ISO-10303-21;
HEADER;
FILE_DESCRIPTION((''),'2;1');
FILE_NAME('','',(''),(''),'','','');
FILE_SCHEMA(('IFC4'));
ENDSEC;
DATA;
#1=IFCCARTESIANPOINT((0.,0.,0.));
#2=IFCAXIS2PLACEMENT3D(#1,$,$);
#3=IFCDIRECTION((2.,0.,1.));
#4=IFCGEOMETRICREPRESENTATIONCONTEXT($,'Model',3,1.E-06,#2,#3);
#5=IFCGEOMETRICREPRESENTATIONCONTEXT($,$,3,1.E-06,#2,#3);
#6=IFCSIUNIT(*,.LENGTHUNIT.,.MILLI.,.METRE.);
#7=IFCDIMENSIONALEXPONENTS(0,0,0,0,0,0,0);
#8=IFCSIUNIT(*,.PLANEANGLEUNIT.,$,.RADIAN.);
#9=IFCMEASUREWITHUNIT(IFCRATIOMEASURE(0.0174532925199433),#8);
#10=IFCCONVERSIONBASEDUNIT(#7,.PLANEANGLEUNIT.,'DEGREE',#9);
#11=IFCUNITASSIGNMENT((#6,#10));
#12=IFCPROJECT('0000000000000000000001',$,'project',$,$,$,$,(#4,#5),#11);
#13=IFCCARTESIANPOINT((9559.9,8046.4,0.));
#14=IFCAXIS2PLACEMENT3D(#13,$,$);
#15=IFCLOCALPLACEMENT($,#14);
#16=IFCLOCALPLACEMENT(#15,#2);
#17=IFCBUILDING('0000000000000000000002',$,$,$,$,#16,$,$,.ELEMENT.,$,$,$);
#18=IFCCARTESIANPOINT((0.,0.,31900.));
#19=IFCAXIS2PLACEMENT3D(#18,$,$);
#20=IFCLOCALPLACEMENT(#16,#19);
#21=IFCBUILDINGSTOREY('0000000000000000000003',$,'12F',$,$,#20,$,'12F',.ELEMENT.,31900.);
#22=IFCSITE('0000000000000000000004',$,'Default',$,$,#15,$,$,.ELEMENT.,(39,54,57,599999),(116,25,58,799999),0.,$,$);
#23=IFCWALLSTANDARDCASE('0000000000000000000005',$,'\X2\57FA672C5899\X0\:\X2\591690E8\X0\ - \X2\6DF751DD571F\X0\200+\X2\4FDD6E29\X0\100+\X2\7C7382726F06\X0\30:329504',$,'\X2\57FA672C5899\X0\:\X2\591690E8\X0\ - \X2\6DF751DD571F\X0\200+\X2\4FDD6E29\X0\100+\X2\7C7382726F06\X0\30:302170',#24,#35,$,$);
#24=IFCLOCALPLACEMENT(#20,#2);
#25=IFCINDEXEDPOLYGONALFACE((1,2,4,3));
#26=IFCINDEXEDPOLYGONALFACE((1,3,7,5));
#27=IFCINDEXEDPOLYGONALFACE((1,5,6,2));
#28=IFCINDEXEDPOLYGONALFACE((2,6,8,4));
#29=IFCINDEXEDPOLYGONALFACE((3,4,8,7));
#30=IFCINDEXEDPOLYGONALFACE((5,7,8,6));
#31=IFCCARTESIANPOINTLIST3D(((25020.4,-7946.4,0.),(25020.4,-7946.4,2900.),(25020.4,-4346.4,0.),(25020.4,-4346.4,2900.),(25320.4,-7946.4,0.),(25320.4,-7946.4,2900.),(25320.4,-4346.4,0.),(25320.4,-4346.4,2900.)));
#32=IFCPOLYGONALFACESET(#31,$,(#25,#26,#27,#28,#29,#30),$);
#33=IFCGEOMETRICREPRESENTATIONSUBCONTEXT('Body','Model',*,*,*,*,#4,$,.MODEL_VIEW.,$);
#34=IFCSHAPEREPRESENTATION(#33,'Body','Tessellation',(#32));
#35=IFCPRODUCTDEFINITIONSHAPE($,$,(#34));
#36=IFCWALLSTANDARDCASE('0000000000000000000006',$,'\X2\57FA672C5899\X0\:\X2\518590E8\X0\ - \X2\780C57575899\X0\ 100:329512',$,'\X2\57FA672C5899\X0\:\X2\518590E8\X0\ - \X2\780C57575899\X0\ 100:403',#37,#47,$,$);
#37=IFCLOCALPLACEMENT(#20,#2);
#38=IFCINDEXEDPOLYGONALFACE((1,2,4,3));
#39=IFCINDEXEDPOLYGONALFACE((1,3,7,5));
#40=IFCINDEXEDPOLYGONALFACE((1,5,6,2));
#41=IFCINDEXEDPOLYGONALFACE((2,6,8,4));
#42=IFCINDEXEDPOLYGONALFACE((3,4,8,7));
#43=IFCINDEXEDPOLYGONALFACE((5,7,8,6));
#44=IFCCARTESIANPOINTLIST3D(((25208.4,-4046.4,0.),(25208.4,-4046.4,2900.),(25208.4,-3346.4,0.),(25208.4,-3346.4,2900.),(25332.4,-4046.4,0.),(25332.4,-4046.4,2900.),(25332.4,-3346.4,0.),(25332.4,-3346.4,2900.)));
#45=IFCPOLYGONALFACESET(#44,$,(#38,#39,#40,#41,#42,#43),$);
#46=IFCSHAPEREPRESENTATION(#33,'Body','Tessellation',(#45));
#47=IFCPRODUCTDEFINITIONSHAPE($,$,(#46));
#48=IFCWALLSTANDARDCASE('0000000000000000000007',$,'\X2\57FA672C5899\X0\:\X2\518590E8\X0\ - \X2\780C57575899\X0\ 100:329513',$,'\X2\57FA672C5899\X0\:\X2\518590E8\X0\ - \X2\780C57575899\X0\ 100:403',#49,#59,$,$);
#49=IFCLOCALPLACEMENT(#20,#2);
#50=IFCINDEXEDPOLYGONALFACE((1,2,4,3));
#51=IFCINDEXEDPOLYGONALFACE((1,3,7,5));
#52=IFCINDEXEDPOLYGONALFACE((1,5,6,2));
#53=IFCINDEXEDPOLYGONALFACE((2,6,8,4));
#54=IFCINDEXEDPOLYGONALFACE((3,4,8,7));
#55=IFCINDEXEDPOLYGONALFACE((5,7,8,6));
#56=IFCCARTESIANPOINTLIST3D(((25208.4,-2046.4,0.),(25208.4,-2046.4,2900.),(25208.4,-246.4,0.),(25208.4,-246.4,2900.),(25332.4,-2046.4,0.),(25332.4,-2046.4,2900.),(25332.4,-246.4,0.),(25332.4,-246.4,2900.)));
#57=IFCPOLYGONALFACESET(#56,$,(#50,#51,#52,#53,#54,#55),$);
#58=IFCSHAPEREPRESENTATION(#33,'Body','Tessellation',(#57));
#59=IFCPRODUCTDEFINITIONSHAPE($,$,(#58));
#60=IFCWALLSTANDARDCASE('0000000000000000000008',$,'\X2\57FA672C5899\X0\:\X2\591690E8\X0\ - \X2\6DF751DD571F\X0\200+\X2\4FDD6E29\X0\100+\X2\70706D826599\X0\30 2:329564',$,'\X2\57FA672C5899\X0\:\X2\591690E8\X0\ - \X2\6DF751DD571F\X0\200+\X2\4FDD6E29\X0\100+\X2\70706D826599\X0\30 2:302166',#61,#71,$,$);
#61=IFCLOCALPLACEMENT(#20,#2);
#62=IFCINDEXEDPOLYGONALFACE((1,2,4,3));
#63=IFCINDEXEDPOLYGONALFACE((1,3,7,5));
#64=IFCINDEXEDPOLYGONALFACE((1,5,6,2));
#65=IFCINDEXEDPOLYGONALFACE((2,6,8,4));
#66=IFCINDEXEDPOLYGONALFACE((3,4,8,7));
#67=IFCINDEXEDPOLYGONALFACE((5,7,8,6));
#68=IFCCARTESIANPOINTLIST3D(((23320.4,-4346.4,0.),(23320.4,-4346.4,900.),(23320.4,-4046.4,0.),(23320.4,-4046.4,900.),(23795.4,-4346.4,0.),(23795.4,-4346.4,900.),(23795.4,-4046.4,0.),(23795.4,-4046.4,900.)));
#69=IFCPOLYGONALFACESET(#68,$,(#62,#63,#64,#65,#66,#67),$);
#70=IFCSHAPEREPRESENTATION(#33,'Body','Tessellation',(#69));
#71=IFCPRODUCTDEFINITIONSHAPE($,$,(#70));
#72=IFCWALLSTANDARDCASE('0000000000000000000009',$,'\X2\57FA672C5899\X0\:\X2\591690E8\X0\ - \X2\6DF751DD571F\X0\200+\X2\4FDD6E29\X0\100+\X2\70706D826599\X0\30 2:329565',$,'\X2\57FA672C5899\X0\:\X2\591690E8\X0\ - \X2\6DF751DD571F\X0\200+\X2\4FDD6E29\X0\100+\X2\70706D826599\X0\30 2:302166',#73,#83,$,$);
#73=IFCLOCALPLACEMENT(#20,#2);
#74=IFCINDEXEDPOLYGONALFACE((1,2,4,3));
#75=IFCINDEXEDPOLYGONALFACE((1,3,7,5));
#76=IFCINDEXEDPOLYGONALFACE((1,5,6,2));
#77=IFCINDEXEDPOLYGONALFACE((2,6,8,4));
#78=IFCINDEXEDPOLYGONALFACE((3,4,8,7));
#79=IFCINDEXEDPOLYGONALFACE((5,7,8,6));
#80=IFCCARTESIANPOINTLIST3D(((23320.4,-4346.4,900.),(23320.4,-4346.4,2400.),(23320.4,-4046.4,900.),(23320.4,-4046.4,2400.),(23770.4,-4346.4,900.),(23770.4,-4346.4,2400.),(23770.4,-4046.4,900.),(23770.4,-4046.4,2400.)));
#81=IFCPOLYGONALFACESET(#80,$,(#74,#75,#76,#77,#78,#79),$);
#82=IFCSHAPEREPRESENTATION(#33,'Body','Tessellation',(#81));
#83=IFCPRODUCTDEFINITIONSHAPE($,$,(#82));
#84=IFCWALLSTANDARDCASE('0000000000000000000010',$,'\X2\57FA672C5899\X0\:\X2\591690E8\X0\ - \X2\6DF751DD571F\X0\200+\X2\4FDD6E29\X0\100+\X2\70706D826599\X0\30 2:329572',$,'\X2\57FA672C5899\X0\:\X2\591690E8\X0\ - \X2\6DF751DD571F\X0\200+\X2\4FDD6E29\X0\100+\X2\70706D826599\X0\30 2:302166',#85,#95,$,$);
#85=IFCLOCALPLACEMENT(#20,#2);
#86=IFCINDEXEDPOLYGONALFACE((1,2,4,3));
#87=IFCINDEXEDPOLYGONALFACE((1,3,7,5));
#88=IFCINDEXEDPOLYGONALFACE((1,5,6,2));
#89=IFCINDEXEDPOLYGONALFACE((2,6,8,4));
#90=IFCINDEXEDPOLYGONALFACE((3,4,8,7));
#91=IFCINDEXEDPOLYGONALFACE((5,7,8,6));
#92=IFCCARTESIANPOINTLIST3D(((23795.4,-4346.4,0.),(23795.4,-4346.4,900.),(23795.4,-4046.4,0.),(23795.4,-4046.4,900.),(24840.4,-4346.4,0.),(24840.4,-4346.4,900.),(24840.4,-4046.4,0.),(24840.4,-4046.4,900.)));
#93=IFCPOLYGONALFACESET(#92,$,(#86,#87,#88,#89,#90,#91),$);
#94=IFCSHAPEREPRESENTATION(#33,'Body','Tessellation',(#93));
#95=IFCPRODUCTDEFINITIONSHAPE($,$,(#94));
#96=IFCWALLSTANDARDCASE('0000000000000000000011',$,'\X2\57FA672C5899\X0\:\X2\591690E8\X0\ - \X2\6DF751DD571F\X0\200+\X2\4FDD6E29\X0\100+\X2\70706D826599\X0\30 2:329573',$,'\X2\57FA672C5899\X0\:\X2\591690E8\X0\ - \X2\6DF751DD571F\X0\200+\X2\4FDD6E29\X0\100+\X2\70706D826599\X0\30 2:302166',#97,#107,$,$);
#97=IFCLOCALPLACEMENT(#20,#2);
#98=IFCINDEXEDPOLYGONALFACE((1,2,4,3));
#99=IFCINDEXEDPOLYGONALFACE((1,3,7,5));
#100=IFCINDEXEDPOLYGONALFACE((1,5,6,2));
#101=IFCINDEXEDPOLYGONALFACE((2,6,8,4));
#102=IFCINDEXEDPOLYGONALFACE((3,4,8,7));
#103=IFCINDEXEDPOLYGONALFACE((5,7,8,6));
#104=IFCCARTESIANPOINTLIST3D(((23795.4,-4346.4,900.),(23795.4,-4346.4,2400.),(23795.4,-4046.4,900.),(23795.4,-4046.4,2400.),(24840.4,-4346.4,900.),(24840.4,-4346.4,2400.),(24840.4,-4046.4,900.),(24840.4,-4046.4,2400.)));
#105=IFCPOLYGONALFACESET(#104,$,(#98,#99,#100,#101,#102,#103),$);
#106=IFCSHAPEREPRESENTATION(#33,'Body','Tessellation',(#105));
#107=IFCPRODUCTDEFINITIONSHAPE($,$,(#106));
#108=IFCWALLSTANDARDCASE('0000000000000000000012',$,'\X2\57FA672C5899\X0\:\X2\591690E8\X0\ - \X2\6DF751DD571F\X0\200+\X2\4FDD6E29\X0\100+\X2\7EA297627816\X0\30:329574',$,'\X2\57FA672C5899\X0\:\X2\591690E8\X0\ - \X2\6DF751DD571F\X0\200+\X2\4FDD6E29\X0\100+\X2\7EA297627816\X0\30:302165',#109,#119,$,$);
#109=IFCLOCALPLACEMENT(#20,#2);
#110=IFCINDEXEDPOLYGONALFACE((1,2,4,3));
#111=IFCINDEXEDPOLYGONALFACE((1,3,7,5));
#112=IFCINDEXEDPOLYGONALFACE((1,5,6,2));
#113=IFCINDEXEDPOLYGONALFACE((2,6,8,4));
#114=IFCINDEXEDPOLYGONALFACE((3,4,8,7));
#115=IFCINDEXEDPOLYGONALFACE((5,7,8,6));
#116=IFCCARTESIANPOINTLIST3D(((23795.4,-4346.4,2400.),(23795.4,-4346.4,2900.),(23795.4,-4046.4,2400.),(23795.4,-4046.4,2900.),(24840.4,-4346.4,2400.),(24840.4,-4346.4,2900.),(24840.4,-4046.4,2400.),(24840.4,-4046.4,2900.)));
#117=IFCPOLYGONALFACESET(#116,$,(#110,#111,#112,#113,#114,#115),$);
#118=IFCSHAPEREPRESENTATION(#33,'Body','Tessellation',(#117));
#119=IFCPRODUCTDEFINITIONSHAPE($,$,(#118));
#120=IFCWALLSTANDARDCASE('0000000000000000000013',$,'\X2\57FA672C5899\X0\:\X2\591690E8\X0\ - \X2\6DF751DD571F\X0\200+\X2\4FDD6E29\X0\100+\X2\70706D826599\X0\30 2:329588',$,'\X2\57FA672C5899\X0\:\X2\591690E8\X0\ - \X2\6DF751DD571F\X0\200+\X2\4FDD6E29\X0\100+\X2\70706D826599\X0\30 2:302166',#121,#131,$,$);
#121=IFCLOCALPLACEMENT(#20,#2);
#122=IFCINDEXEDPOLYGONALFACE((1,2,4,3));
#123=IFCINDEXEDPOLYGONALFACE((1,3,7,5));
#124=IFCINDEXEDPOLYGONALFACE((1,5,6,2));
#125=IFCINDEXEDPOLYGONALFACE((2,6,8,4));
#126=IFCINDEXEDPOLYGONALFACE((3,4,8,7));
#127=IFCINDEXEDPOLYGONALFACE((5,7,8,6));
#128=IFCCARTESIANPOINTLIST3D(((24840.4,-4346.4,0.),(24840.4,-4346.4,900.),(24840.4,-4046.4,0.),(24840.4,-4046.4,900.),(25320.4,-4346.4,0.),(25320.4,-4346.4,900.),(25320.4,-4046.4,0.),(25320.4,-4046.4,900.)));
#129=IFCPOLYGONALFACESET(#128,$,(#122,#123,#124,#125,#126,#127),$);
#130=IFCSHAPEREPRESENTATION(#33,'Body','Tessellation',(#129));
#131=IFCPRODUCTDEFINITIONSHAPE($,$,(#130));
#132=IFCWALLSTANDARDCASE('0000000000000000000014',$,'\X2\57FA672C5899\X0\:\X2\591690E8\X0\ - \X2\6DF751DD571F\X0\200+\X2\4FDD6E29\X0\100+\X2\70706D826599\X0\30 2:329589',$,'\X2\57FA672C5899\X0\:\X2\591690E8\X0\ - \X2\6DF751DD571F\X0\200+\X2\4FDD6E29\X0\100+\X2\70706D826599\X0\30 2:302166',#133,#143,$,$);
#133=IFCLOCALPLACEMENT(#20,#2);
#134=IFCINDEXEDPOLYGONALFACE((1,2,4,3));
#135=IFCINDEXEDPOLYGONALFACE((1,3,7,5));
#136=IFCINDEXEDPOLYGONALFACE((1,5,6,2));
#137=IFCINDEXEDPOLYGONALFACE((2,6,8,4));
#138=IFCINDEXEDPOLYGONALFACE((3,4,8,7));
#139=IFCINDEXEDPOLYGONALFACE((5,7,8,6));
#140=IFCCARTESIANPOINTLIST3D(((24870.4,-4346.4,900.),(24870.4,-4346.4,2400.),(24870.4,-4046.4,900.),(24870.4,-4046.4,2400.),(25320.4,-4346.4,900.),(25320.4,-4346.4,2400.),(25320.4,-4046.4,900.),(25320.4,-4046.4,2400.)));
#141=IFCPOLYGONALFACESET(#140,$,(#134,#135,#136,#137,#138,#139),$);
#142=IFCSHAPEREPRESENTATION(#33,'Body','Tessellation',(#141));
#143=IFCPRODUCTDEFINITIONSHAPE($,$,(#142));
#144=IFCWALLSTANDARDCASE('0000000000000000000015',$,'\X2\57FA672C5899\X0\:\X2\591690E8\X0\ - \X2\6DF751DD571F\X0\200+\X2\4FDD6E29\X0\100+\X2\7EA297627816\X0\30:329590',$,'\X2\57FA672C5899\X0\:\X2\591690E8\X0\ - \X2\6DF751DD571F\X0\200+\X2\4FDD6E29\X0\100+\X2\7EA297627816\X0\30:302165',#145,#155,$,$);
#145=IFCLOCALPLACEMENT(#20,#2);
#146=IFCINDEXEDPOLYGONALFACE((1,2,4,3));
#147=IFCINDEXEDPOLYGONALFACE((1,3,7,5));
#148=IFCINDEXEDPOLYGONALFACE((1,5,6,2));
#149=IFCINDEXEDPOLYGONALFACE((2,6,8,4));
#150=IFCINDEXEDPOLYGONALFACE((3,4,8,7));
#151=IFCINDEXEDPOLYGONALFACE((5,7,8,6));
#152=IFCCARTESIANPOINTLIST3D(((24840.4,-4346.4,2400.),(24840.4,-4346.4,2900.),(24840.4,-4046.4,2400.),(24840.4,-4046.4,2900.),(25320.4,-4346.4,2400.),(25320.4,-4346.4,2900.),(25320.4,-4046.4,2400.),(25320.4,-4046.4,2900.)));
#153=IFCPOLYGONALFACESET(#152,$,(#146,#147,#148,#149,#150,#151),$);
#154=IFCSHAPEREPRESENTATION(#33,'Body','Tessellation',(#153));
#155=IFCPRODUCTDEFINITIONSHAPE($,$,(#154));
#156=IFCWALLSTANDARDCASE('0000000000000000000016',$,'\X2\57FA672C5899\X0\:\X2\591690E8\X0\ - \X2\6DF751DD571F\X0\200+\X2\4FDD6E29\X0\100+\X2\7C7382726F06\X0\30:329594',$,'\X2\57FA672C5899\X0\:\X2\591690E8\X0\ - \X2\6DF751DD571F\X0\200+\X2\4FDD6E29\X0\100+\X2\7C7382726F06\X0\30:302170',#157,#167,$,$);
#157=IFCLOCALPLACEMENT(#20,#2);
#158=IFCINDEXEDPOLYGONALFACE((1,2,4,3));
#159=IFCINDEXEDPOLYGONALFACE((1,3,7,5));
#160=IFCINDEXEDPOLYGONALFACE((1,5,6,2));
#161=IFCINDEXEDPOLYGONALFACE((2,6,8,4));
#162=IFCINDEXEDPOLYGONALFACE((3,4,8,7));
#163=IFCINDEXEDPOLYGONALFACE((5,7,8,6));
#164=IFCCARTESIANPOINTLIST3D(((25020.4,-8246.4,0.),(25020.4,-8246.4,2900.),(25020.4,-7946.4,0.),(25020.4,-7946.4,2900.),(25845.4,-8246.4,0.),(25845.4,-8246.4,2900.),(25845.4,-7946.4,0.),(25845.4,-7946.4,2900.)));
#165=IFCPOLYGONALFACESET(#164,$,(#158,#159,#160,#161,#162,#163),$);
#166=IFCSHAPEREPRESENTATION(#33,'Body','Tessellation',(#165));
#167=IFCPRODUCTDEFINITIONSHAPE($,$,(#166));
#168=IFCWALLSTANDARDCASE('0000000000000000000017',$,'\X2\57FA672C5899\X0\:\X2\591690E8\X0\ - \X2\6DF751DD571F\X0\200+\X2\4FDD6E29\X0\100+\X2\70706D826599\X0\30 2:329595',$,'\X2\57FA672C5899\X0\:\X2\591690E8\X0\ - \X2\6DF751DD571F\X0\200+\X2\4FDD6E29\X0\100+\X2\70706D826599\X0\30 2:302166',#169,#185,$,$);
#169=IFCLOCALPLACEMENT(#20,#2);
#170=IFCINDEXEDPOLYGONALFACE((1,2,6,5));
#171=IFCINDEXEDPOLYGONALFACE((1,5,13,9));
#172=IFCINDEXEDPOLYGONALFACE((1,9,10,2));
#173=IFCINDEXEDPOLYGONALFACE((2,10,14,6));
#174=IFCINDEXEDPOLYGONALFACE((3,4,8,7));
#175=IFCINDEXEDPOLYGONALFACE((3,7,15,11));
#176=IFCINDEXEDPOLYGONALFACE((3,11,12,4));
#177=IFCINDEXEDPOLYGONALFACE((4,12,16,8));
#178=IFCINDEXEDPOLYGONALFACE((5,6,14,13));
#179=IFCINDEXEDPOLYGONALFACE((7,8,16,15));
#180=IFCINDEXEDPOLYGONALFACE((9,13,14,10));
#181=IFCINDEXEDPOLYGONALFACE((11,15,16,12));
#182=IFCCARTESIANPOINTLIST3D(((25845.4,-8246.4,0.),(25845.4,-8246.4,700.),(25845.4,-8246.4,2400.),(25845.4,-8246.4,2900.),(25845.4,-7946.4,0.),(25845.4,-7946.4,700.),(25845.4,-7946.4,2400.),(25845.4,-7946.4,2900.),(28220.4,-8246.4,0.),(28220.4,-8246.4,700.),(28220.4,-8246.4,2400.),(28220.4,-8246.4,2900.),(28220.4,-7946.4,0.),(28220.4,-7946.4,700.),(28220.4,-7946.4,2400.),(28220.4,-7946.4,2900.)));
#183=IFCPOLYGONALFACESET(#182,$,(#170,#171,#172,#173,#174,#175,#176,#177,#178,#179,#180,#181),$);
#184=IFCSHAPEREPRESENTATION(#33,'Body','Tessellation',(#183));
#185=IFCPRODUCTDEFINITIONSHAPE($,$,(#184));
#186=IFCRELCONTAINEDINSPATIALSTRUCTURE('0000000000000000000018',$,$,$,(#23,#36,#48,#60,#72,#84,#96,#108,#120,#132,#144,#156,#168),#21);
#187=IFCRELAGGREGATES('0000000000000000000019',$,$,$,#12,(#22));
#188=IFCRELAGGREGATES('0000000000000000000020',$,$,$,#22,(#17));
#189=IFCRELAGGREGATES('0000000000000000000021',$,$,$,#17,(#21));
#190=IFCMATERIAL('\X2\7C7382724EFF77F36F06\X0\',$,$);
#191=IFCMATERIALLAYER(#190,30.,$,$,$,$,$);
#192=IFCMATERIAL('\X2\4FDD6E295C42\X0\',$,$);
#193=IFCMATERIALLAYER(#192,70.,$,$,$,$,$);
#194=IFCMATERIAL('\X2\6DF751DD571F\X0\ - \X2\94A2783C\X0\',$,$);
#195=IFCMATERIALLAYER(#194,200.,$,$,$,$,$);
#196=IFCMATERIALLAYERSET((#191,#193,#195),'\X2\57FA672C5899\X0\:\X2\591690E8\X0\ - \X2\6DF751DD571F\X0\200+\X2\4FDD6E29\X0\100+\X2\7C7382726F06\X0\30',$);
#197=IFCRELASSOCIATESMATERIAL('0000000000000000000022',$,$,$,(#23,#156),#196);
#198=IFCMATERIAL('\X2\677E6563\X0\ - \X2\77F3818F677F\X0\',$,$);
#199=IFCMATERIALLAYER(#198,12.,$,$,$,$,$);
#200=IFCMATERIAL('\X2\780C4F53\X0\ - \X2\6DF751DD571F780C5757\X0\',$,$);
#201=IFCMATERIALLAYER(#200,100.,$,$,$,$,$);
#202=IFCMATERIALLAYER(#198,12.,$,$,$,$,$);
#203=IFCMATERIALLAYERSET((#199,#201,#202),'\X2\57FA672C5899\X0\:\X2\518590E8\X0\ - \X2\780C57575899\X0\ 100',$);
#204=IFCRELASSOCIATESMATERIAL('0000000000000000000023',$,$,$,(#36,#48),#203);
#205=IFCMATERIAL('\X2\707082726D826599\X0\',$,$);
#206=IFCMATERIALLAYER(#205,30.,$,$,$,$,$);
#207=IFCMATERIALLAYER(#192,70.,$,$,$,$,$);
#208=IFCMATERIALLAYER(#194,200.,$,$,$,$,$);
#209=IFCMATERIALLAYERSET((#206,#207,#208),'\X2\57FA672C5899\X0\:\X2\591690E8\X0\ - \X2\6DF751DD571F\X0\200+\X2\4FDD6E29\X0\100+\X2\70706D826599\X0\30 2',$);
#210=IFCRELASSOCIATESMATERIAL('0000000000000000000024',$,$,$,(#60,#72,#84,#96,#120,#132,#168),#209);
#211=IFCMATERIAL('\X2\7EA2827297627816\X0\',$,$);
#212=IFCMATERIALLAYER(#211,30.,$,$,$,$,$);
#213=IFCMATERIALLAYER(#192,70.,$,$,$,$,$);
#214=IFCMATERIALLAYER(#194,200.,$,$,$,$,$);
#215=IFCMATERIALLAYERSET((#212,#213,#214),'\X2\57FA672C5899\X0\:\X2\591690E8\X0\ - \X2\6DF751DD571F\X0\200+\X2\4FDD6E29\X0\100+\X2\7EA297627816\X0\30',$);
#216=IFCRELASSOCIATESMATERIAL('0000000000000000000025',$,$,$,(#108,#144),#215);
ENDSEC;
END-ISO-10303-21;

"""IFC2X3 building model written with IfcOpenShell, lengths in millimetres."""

from ifc_helpers import new_model, entity, si_unit, converted_unit, direction, frame, frame_2d, origin, place, context, subcontext, project, spatial, rectangle, extrude, material, layer, layer_set, layer_usage, element, save


model = new_model("IFC2X3")

# Units and contexts
model_context = context("Model", 3, precision=1e-06, world=origin(), true_north=direction((2.0, 0.0, 1.0)))
context_of_model = context(None, 3, precision=1e-06, world=origin(), true_north=direction((2.0, 0.0, 1.0)))
body_context = subcontext(model_context, "Body", "Model", "MODEL_VIEW")
ifc_project = project(units=[si_unit("LENGTHUNIT", "METRE", prefix="MILLI"), converted_unit("PLANEANGLEUNIT", "DEGREE", entity("IfcRatioMeasure", 0.0174532925199433), si_unit("PLANEANGLEUNIT", "RADIAN"), dimensions=[0, 0, 0, 0, 0, 0, 0])], contexts=[model_context, context_of_model])

# Site, building, storey
site_placement = place(None, frame((9559.9, 8046.4, 0.0)))
site = spatial("IfcSite", under=ifc_project, at=site_placement, Name="Default", CompositionType="ELEMENT", RefLatitude=(39, 54, 57, 599999), RefLongitude=(116, 25, 58, 799999), RefElevation=0.0)
building_placement = place(site_placement, origin())
building = spatial("IfcBuilding", under=site, at=building_placement, CompositionType="ELEMENT")
storey_placement = place(building_placement, frame((0.0, 0.0, 31900.0)))
storey = spatial("IfcBuildingStorey", under=building, at=storey_placement, Name="12F", LongName="12F", CompositionType="ELEMENT", Elevation=31900.0)

# Shared definitions
ifc_material_1 = material(Name="混凝土 - 钢砼")
ifc_material_2 = material(Name="红色面砖")
ifc_layer_1 = layer(ifc_material_2, 30.0)
ifc_material_3 = material(Name="保温层")
ifc_layer_2 = layer(ifc_material_3, 70.0)
ifc_layer_3 = layer(ifc_material_1, 200.0)
ifc_layer_set_1 = layer_set([ifc_layer_1, ifc_layer_2, ifc_layer_3], Name="基本墙:外部 - 混凝土200+保温100+红面砖30")

# Shared definitions
ifc_material_4 = material(Name="米色仿石漆")
ifc_layer_4 = layer(ifc_material_4, 30.0)
ifc_layer_5 = layer(ifc_material_3, 70.0)
ifc_layer_6 = layer(ifc_material_1, 200.0)
ifc_layer_set_2 = layer_set([ifc_layer_4, ifc_layer_5, ifc_layer_6], Name="基本墙:外部 - 混凝土200+保温100+米色漆30")

# Shared definitions
ifc_material_5 = material(Name="灰色涂料")
ifc_layer_7 = layer(ifc_material_5, 30.0)
ifc_layer_8 = layer(ifc_material_3, 70.0)
ifc_layer_9 = layer(ifc_material_1, 200.0)
ifc_layer_set_3 = layer_set([ifc_layer_7, ifc_layer_8, ifc_layer_9], Name="基本墙:外部 - 混凝土200+保温100+灰涂料30 2")
ifc_material_6 = material(Name="松散 - 石膏板")
ifc_layer_10 = layer(ifc_material_6, 12.0)
ifc_material_7 = material(Name="砌体 - 混凝土砌块")
ifc_layer_11 = layer(ifc_material_7, 100.0)
ifc_layer_12 = layer(ifc_material_6, 12.0)
ifc_layer_set_4 = layer_set([ifc_layer_10, ifc_layer_11, ifc_layer_12], Name="基本墙:内部 - 砌块墙 100")

# Walls
ifc_layer_usage_1 = layer_usage(ifc_layer_set_2, "AXIS2", "POSITIVE", -150.0)
wall_1_placement = place(storey_placement, frame((25170.4, -4346.4, 0.0), z_axis=(0.0, 0.0, 1.0), x_axis=(0.0, -1.0, 0.0)))
element("IfcWallStandardCase", 1, at=wall_1_placement, inside=storey, material=ifc_layer_usage_1, Name="基本墙:外部 - 混凝土200+保温100+米色漆30:329504", ObjectType="基本墙:外部 - 混凝土200+保温100+米色漆30:302170", context=body_context, shape_type="SweptSolid", body=[
    extrude(rectangle(XDim=3600.0, YDim=300.0, at=frame_2d((1800.0, 0.0), x_axis=(-1.0, 0.0))), origin(), (0.0, 0.0, 1.0), 2900.0),
])
ifc_layer_usage_2 = layer_usage(ifc_layer_set_4, "AXIS2", "POSITIVE", -62.0)
wall_2_placement = place(storey_placement, frame((25270.4, -4046.4, 0.0), z_axis=(0.0, 0.0, 1.0), x_axis=(0.0, 1.0, 0.0)))
element("IfcWallStandardCase", 2, at=wall_2_placement, inside=storey, material=ifc_layer_usage_2, Name="基本墙:内部 - 砌块墙 100:329512", ObjectType="基本墙:内部 - 砌块墙 100:403", context=body_context, shape_type="SweptSolid", body=[
    extrude(rectangle(XDim=700.0, YDim=124.0, at=frame_2d((350.0, 0.0), x_axis=(-1.0, 0.0))), origin(), (0.0, 0.0, 1.0), 2900.0),
])
ifc_layer_usage_3 = layer_usage(ifc_layer_set_4, "AXIS2", "POSITIVE", -62.0)
wall_3_placement = place(storey_placement, frame((25270.4, -246.4, 0.0), z_axis=(0.0, 0.0, 1.0), x_axis=(0.0, -1.0, 0.0)))
element("IfcWallStandardCase", 3, at=wall_3_placement, inside=storey, material=ifc_layer_usage_3, Name="基本墙:内部 - 砌块墙 100:329513", ObjectType="基本墙:内部 - 砌块墙 100:403", context=body_context, shape_type="SweptSolid", body=[
    extrude(rectangle(XDim=1800.0, YDim=124.0, at=frame_2d((900.0, 0.0), x_axis=(-1.0, 0.0))), origin(), (0.0, 0.0, 1.0), 2900.0),
])
ifc_layer_usage_4 = layer_usage(ifc_layer_set_3, "AXIS2", "POSITIVE", -150.0)
wall_4_placement = place(storey_placement, frame((23320.4, -4196.4, 0.0)))
element("IfcWallStandardCase", 4, at=wall_4_placement, inside=storey, material=ifc_layer_usage_4, Name="基本墙:外部 - 混凝土200+保温100+灰涂料30 2:329564", ObjectType="基本墙:外部 - 混凝土200+保温100+灰涂料30 2:302166", context=body_context, shape_type="SweptSolid", body=[
    extrude(rectangle(XDim=475.0, YDim=300.0, at=frame_2d((237.5, 0.0), x_axis=(-1.0, 0.0))), origin(), (0.0, 0.0, 1.0), 900.0),
])
ifc_layer_usage_5 = layer_usage(ifc_layer_set_3, "AXIS2", "POSITIVE", -150.0)
wall_5_placement = place(storey_placement, frame((23320.4, -4196.4, 900.0)))
element("IfcWallStandardCase", 5, at=wall_5_placement, inside=storey, material=ifc_layer_usage_5, Name="基本墙:外部 - 混凝土200+保温100+灰涂料30 2:329565", ObjectType="基本墙:外部 - 混凝土200+保温100+灰涂料30 2:302166", context=body_context, shape_type="SweptSolid", body=[
    extrude(rectangle(XDim=450.0, YDim=300.0, at=frame_2d((225.0, 0.0), x_axis=(-1.0, 0.0))), origin(), (0.0, 0.0, 1.0), 1500.0),
])

# Walls
ifc_layer_usage_6 = layer_usage(ifc_layer_set_3, "AXIS2", "POSITIVE", -150.0)
wall_6_placement = place(storey_placement, frame((23795.4, -4196.4, 0.0)))
element("IfcWallStandardCase", 6, at=wall_6_placement, inside=storey, material=ifc_layer_usage_6, Name="基本墙:外部 - 混凝土200+保温100+灰涂料30 2:329572", ObjectType="基本墙:外部 - 混凝土200+保温100+灰涂料30 2:302166", context=body_context, shape_type="SweptSolid", body=[
    extrude(rectangle(XDim=1045.0, YDim=300.0, at=frame_2d((522.5, 0.0), x_axis=(-1.0, 0.0))), origin(), (0.0, 0.0, 1.0), 900.0),
])
ifc_layer_usage_7 = layer_usage(ifc_layer_set_3, "AXIS2", "POSITIVE", -150.0)
wall_7_placement = place(storey_placement, frame((23795.4, -4196.4, 900.0)))
element("IfcWallStandardCase", 7, at=wall_7_placement, inside=storey, material=ifc_layer_usage_7, Name="基本墙:外部 - 混凝土200+保温100+灰涂料30 2:329573", ObjectType="基本墙:外部 - 混凝土200+保温100+灰涂料30 2:302166", context=body_context, shape_type="SweptSolid", body=[
    extrude(rectangle(XDim=1045.0, YDim=300.0, at=frame_2d((522.5, 0.0), x_axis=(-1.0, 0.0))), origin(), (0.0, 0.0, 1.0), 1500.0),
])
ifc_layer_usage_8 = layer_usage(ifc_layer_set_1, "AXIS2", "POSITIVE", -150.0)
wall_8_placement = place(storey_placement, frame((23795.4, -4196.4, 2400.0)))
element("IfcWallStandardCase", 8, at=wall_8_placement, inside=storey, material=ifc_layer_usage_8, Name="基本墙:外部 - 混凝土200+保温100+红面砖30:329574", ObjectType="基本墙:外部 - 混凝土200+保温100+红面砖30:302165", context=body_context, shape_type="SweptSolid", body=[
    extrude(rectangle(XDim=1045.0, YDim=300.0, at=frame_2d((522.5, 0.0), x_axis=(-1.0, 0.0))), origin(), (0.0, 0.0, 1.0), 500.0),
])
ifc_layer_usage_9 = layer_usage(ifc_layer_set_3, "AXIS2", "POSITIVE", -150.0)
wall_9_placement = place(storey_placement, frame((24840.4, -4196.4, 0.0)))
element("IfcWallStandardCase", 9, at=wall_9_placement, inside=storey, material=ifc_layer_usage_9, Name="基本墙:外部 - 混凝土200+保温100+灰涂料30 2:329588", ObjectType="基本墙:外部 - 混凝土200+保温100+灰涂料30 2:302166", context=body_context, shape_type="SweptSolid", body=[
    extrude(rectangle(XDim=480.0, YDim=300.0, at=frame_2d((240.0, 0.0), x_axis=(-1.0, 0.0))), origin(), (0.0, 0.0, 1.0), 900.0),
])
ifc_layer_usage_10 = layer_usage(ifc_layer_set_3, "AXIS2", "POSITIVE", -150.0)
wall_10_placement = place(storey_placement, frame((24870.4, -4196.4, 900.0)))
element("IfcWallStandardCase", 10, at=wall_10_placement, inside=storey, material=ifc_layer_usage_10, Name="基本墙:外部 - 混凝土200+保温100+灰涂料30 2:329589", ObjectType="基本墙:外部 - 混凝土200+保温100+灰涂料30 2:302166", context=body_context, shape_type="SweptSolid", body=[
    extrude(rectangle(XDim=450.0, YDim=300.0, at=frame_2d((225.0, 0.0), x_axis=(-1.0, 0.0))), origin(), (0.0, 0.0, 1.0), 1500.0),
])
ifc_layer_usage_11 = layer_usage(ifc_layer_set_1, "AXIS2", "POSITIVE", -150.0)
wall_11_placement = place(storey_placement, frame((24840.4, -4196.4, 2400.0)))
element("IfcWallStandardCase", 11, at=wall_11_placement, inside=storey, material=ifc_layer_usage_11, Name="基本墙:外部 - 混凝土200+保温100+红面砖30:329590", ObjectType="基本墙:外部 - 混凝土200+保温100+红面砖30:302165", context=body_context, shape_type="SweptSolid", body=[
    extrude(rectangle(XDim=480.0, YDim=300.0, at=frame_2d((240.0, 0.0), x_axis=(-1.0, 0.0))), origin(), (0.0, 0.0, 1.0), 500.0),
])
ifc_layer_usage_12 = layer_usage(ifc_layer_set_2, "AXIS2", "POSITIVE", -150.0)
wall_12_placement = place(storey_placement, frame((25020.4, -8096.4, 0.0)))
element("IfcWallStandardCase", 12, at=wall_12_placement, inside=storey, material=ifc_layer_usage_12, Name="基本墙:外部 - 混凝土200+保温100+米色漆30:329594", ObjectType="基本墙:外部 - 混凝土200+保温100+米色漆30:302170", context=body_context, shape_type="SweptSolid", body=[
    extrude(rectangle(XDim=825.0, YDim=300.0, at=frame_2d((412.5, 0.0), x_axis=(-1.0, 0.0))), origin(), (0.0, 0.0, 1.0), 2900.0),
])

# Wall, opening
ifc_layer_usage_13 = layer_usage(ifc_layer_set_3, "AXIS2", "POSITIVE", -150.0)
wall_13_placement = place(storey_placement, frame((25845.4, -8096.4, 0.0)))
wall_13 = element("IfcWallStandardCase", 13, at=wall_13_placement, inside=storey, material=ifc_layer_usage_13, Name="基本墙:外部 - 混凝土200+保温100+灰涂料30 2:329595", ObjectType="基本墙:外部 - 混凝土200+保温100+灰涂料30 2:302166", context=body_context, shape_type="SweptSolid", body=[
    extrude(rectangle(XDim=2375.0, YDim=300.0, at=frame_2d((1187.5, 0.0), x_axis=(-1.0, 0.0))), origin(), (0.0, 0.0, 1.0), 2900.0),
])
opening_1_placement = place(wall_13_placement, frame((-25.0, -150.0, 700.0)))
element("IfcOpeningElement", 14, at=opening_1_placement, cuts=wall_13, ObjectType="Opening", context=body_context, shape_type="SweptSolid", body=[
    extrude(rectangle(XDim=1700.0, YDim=2400.0, at=frame_2d((850.0, 1200.0), x_axis=(1.0, 0.0))), frame((0.0, 0.0, 0.0), z_axis=(0.0, 1.0, 0.0), x_axis=(0.0, 0.0, 1.0)), (0.0, 0.0, 1.0), 300.0),
])

save(model, "model.ifc")
